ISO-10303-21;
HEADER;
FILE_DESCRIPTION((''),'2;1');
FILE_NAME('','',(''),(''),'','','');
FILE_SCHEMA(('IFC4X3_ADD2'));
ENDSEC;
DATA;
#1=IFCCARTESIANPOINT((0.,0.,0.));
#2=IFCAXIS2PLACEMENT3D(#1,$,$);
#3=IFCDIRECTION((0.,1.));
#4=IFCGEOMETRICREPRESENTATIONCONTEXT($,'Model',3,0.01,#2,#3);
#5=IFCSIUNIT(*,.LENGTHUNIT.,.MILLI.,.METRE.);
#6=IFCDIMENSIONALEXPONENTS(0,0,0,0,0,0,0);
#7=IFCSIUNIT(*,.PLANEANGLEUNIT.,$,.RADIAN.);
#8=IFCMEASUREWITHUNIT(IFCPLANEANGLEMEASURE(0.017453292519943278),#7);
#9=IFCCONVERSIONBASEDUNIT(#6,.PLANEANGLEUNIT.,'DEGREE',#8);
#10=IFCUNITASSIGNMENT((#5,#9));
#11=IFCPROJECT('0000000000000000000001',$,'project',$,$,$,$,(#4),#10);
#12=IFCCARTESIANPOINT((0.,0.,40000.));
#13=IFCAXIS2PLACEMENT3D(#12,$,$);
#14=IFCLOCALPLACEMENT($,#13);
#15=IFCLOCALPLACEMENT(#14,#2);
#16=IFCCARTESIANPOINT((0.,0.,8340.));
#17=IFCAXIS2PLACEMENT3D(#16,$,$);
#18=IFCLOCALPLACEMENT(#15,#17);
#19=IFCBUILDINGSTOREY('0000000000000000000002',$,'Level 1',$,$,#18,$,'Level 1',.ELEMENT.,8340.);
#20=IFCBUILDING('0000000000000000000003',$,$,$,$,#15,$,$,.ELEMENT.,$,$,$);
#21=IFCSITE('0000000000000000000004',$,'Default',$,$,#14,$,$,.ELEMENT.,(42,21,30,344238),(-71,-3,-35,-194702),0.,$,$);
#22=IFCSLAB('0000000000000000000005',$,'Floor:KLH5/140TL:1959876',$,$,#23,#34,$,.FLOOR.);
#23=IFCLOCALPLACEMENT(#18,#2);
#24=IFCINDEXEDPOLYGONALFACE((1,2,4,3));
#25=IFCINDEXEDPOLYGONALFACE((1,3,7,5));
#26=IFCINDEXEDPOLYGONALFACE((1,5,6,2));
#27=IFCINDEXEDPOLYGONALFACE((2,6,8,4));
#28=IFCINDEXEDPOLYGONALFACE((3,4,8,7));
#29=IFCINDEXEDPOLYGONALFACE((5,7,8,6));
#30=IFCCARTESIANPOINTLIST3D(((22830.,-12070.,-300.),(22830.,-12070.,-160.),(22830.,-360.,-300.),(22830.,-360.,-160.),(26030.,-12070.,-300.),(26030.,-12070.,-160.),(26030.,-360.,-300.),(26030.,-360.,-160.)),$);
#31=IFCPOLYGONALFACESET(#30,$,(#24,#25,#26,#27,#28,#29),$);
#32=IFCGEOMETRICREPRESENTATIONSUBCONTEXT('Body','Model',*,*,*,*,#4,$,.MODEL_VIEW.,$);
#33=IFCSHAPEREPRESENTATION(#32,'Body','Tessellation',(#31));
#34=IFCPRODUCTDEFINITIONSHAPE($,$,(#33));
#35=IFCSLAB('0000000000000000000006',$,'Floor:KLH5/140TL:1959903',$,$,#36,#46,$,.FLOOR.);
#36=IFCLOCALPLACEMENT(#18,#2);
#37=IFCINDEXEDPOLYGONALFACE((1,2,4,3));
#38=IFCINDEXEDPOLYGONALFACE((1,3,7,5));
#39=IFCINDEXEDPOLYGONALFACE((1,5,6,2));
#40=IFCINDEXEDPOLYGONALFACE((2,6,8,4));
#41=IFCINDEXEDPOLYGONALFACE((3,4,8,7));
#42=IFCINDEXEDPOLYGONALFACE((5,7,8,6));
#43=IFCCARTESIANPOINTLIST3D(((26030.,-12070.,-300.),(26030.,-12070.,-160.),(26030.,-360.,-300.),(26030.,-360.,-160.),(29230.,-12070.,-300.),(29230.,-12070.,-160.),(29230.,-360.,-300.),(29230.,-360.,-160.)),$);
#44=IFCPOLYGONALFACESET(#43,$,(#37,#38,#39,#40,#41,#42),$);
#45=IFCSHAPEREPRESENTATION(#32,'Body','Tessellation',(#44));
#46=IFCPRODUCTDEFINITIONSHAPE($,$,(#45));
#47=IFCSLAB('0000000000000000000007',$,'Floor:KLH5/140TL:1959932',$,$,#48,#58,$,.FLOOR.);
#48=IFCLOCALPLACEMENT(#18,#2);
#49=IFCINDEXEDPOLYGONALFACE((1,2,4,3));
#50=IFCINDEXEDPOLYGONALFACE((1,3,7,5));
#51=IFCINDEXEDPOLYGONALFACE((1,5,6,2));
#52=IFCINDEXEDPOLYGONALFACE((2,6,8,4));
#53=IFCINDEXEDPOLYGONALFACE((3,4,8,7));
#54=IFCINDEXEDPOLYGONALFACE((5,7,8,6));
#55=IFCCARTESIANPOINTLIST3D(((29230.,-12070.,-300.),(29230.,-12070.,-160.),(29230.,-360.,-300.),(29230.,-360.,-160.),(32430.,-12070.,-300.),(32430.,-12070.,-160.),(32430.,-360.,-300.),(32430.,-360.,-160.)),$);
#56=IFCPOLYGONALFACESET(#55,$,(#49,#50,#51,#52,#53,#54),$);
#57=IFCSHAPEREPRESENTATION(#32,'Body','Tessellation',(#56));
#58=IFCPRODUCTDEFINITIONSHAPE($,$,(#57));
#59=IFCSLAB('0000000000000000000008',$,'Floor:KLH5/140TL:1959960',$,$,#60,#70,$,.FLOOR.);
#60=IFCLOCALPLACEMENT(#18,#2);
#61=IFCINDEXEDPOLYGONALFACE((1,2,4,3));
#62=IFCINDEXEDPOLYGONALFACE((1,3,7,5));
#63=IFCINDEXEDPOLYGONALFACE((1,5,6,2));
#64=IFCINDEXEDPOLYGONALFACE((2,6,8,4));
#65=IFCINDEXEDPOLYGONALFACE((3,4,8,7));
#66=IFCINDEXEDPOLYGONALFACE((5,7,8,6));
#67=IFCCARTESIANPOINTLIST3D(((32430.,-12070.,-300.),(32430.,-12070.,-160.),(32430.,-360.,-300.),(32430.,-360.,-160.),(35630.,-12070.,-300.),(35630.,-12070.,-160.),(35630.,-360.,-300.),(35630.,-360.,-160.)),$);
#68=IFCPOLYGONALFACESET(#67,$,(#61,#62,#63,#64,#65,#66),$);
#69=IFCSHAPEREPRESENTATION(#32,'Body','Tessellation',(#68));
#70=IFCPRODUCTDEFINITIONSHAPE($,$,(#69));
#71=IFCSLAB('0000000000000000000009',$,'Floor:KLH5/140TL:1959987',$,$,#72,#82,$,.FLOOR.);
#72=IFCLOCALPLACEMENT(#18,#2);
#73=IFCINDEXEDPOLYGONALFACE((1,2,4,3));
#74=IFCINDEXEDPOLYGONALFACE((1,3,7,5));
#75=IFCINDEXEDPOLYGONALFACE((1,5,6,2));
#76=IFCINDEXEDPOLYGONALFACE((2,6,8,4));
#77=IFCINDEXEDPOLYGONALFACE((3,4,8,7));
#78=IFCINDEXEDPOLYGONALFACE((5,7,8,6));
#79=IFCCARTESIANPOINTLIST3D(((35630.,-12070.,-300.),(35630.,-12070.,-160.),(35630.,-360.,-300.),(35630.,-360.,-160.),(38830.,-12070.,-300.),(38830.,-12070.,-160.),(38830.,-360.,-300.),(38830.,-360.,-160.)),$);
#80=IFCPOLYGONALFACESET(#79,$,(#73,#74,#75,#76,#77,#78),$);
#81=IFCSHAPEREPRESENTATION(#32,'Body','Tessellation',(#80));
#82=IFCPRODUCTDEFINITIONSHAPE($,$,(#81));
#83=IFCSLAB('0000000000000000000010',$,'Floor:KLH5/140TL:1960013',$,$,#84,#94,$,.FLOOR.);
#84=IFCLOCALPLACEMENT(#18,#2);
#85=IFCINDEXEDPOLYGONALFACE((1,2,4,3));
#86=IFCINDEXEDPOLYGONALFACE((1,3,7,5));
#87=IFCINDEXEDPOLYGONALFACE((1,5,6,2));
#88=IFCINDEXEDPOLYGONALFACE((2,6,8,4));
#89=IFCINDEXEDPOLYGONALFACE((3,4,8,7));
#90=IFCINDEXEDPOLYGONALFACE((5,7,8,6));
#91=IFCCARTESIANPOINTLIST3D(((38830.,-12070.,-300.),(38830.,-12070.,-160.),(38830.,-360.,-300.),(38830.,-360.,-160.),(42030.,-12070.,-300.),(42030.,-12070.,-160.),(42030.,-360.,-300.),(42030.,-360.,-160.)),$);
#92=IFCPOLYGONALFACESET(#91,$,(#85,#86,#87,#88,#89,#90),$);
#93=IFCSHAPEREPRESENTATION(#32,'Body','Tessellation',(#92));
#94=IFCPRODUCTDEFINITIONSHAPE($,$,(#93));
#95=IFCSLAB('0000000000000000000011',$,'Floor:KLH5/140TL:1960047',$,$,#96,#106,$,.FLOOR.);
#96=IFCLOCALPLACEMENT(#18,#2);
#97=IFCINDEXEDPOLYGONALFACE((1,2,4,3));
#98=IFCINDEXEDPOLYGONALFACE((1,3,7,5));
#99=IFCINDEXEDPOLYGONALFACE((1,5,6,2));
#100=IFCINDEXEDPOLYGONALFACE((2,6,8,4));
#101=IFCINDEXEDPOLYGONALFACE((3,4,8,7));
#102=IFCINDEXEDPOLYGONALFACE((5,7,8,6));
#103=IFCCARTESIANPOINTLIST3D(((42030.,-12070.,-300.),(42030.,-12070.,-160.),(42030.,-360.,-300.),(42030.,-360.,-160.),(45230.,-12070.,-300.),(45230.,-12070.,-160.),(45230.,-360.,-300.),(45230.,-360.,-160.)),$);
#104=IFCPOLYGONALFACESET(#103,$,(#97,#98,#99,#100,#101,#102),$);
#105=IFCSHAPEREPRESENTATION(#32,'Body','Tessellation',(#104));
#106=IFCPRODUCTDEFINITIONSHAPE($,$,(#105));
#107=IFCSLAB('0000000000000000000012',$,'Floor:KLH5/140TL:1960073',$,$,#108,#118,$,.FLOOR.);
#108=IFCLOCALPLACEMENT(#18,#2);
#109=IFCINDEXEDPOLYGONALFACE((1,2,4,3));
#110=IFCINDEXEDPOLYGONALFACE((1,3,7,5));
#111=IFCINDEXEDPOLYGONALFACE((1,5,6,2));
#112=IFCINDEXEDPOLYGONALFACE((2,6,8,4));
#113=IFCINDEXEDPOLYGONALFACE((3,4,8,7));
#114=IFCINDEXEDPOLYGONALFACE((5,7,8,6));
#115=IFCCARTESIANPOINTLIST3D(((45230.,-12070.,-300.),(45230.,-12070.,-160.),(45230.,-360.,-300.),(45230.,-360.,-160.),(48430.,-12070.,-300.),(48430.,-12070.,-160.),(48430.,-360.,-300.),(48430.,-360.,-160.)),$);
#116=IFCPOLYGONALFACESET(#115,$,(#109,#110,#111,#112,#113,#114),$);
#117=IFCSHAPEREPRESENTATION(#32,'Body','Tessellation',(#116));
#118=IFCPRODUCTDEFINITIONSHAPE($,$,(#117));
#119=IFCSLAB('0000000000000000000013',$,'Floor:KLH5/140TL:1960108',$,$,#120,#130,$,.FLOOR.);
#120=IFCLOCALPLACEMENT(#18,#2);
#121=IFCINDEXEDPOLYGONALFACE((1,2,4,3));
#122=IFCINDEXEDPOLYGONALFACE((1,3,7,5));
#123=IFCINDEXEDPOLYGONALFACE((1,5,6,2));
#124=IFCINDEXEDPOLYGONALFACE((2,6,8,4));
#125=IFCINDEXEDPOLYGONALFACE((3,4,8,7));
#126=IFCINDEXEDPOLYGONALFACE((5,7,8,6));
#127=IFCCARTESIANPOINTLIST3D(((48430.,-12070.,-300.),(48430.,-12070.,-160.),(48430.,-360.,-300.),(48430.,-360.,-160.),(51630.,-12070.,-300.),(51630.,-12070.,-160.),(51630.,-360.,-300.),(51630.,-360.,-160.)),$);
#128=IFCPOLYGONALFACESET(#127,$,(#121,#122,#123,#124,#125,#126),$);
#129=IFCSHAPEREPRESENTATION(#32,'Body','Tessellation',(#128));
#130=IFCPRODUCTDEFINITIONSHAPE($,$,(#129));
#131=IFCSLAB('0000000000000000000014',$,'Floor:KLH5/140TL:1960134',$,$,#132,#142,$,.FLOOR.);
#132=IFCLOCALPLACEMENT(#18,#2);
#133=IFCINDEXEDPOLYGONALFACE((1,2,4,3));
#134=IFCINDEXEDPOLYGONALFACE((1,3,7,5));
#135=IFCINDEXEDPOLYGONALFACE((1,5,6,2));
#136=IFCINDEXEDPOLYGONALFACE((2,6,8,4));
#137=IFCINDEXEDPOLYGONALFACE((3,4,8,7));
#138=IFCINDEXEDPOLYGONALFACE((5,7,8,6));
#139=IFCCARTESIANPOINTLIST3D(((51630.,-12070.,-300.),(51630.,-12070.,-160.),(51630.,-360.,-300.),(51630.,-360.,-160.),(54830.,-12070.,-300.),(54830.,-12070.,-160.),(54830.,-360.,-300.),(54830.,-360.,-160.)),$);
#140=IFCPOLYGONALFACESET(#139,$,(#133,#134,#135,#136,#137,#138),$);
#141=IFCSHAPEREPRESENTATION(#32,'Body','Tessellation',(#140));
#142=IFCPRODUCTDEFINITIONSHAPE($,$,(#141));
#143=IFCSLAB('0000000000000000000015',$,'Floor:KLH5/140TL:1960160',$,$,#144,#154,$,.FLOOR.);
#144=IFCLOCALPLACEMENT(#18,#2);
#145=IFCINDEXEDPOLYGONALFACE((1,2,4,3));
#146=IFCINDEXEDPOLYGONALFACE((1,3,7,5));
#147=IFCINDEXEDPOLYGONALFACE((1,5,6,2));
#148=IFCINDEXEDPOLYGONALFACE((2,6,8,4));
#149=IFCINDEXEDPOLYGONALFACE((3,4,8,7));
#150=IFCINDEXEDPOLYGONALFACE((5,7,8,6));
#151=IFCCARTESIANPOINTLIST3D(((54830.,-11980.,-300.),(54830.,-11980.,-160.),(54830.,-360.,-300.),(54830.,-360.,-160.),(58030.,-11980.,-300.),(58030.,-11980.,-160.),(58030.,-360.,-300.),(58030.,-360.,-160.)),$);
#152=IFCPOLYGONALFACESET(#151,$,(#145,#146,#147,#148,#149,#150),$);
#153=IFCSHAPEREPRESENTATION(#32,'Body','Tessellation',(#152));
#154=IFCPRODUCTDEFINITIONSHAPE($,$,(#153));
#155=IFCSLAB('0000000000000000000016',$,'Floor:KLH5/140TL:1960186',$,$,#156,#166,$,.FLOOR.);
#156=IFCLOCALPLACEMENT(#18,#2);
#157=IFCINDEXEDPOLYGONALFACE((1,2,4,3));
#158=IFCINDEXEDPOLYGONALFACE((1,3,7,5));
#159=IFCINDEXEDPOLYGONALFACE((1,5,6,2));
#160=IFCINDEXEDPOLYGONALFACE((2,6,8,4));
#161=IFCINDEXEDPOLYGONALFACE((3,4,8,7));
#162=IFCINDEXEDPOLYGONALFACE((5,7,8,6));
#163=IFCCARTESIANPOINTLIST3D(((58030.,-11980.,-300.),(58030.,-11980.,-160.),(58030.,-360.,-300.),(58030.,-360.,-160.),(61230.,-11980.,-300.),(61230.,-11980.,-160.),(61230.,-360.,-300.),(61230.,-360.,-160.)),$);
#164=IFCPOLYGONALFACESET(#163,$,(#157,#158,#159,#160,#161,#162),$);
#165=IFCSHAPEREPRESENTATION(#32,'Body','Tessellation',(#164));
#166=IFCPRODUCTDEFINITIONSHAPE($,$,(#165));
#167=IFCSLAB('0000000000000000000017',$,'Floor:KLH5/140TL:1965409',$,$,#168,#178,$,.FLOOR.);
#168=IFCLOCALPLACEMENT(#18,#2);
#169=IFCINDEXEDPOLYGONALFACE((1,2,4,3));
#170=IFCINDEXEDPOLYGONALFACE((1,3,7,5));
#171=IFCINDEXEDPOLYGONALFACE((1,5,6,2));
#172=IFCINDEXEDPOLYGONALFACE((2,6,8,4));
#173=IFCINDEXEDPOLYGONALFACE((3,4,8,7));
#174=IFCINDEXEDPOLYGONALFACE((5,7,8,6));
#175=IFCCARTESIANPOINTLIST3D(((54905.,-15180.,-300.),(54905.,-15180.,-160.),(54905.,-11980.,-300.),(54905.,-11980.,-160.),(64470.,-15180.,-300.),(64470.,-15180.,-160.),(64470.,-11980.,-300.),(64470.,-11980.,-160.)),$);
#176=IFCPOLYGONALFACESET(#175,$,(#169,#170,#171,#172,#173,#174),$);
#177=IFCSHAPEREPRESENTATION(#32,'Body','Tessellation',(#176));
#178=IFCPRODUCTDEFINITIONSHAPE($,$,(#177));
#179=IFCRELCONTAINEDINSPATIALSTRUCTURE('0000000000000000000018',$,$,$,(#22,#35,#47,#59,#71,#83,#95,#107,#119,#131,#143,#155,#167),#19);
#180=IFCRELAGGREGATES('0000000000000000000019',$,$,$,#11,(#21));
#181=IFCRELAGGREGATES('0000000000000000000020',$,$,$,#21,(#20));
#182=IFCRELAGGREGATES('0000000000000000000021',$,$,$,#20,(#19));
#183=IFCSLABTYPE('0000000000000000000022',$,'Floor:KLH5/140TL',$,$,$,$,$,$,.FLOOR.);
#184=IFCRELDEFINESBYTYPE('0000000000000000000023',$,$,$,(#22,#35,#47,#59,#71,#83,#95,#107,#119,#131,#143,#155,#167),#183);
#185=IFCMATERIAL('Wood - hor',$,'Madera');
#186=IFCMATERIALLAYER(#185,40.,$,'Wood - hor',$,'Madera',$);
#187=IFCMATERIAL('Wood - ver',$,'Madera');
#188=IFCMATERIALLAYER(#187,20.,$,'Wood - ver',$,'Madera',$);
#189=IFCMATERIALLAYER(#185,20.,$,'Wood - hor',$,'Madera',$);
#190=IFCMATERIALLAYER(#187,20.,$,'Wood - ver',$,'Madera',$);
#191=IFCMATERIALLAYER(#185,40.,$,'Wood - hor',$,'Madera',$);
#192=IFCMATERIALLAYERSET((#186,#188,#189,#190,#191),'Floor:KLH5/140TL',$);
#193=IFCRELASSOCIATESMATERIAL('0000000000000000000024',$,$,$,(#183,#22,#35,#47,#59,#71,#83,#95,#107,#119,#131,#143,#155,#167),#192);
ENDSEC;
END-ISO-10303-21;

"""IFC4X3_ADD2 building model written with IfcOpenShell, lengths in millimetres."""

from ifc_helpers import new_model, entity, si_unit, converted_unit, direction, frame, frame_2d, origin, origin_2d_with_axis, place, context, subcontext, project, spatial, rectangle, extrude, material, layer, layer_set, layer_usage, type_object, element, save


model = new_model("IFC4X3_ADD2")

# Units and contexts
model_context = context("Model", 3, precision=0.01, world=origin(), true_north=direction((0.0, 1.0)))
body_context = subcontext(model_context, "Body", "Model", "MODEL_VIEW")
ifc_project = project(units=[si_unit("LENGTHUNIT", "METRE", prefix="MILLI"), converted_unit("PLANEANGLEUNIT", "DEGREE", entity("IfcPlaneAngleMeasure", 0.017453292519943278), si_unit("PLANEANGLEUNIT", "RADIAN"), dimensions=[0, 0, 0, 0, 0, 0, 0])], contexts=[model_context])

# Site, building, storey
site_placement = place(None, frame((0.0, 0.0, 40000.0)))
site = spatial("IfcSite", under=ifc_project, at=site_placement, Name="Default", CompositionType="ELEMENT", RefLatitude=(42, 21, 30, 344238), RefLongitude=(-71, -3, -35, -194702), RefElevation=0.0)
building_placement = place(site_placement, origin())
building = spatial("IfcBuilding", under=site, at=building_placement, CompositionType="ELEMENT")
storey_placement = place(building_placement, frame((0.0, 0.0, 8340.0)))
storey = spatial("IfcBuildingStorey", under=building, at=storey_placement, Name="Level 1", LongName="Level 1", CompositionType="ELEMENT", Elevation=8340.0)

# Slabs
ifc_material_1 = material(Name="Wood - hor", Category="Madera")
ifc_layer_1 = layer(ifc_material_1, 40.0, Name="Wood - hor", Category="Madera")
ifc_material_2 = material(Name="Wood - ver", Category="Madera")
ifc_layer_2 = layer(ifc_material_2, 20.0, Name="Wood - ver", Category="Madera")
ifc_layer_3 = layer(ifc_material_1, 20.0, Name="Wood - hor", Category="Madera")
ifc_layer_4 = layer(ifc_material_2, 20.0, Name="Wood - ver", Category="Madera")
ifc_layer_5 = layer(ifc_material_1, 40.0, Name="Wood - hor", Category="Madera")
ifc_layer_set = layer_set([ifc_layer_1, ifc_layer_2, ifc_layer_3, ifc_layer_4, ifc_layer_5], Name="Floor:KLH5/140TL")
slab_type = type_object("IfcSlabType", Name="Floor:KLH5/140TL", PredefinedType="FLOOR", material=ifc_layer_set)
ifc_layer_usage_1 = layer_usage(ifc_layer_set, "AXIS3", "POSITIVE", 0.0)
slab_1_placement = place(storey_placement, origin())
element("IfcSlab", 1, at=slab_1_placement, inside=storey, type_object=slab_type, material=ifc_layer_usage_1, Name="Floor:KLH5/140TL:1959876", PredefinedType="FLOOR", context=body_context, shape_type="SweptSolid", body=[
    extrude(rectangle(XDim=11710.0, YDim=3200.0, at=frame_2d((0.0, 0.0), x_axis=(1.0, 0.0))), frame((24430.0, -6215.0, -160.0), z_axis=(0.0, 0.0, -1.0), x_axis=(0.0, 1.0, 0.0)), (0.0, 0.0, 1.0), 140.0),
])
ifc_layer_usage_2 = layer_usage(ifc_layer_set, "AXIS3", "POSITIVE", 0.0)
slab_2_placement = place(storey_placement, origin())
element("IfcSlab", 2, at=slab_2_placement, inside=storey, type_object=slab_type, material=ifc_layer_usage_2, Name="Floor:KLH5/140TL:1959903", PredefinedType="FLOOR", context=body_context, shape_type="SweptSolid", body=[
    extrude(rectangle(XDim=11710.0, YDim=3200.0, at=origin_2d_with_axis()), frame((27630.0, -6215.0, -160.0), z_axis=(0.0, 0.0, -1.0), x_axis=(0.0, 1.0, 0.0)), (0.0, 0.0, 1.0), 140.0),
])
ifc_layer_usage_3 = layer_usage(ifc_layer_set, "AXIS3", "POSITIVE", 0.0)
slab_3_placement = place(storey_placement, origin())
element("IfcSlab", 3, at=slab_3_placement, inside=storey, type_object=slab_type, material=ifc_layer_usage_3, Name="Floor:KLH5/140TL:1959932", PredefinedType="FLOOR", context=body_context, shape_type="SweptSolid", body=[
    extrude(rectangle(XDim=11710.0, YDim=3200.0, at=origin_2d_with_axis()), frame((30830.0, -6215.0, -160.0), z_axis=(0.0, 0.0, -1.0), x_axis=(0.0, 1.0, 0.0)), (0.0, 0.0, 1.0), 140.0),
])
ifc_layer_usage_4 = layer_usage(ifc_layer_set, "AXIS3", "POSITIVE", 0.0)
slab_4_placement = place(storey_placement, origin())
element("IfcSlab", 4, at=slab_4_placement, inside=storey, type_object=slab_type, material=ifc_layer_usage_4, Name="Floor:KLH5/140TL:1959960", PredefinedType="FLOOR", context=body_context, shape_type="SweptSolid", body=[
    extrude(rectangle(XDim=11710.0, YDim=3200.0, at=frame_2d((0.0, 0.0), x_axis=(1.0, 0.0))), frame((34030.0, -6215.0, -160.0), z_axis=(0.0, 0.0, -1.0), x_axis=(0.0, 1.0, 0.0)), (0.0, 0.0, 1.0), 140.0),
])
ifc_layer_usage_5 = layer_usage(ifc_layer_set, "AXIS3", "POSITIVE", 0.0)
slab_5_placement = place(storey_placement, origin())
element("IfcSlab", 5, at=slab_5_placement, inside=storey, type_object=slab_type, material=ifc_layer_usage_5, Name="Floor:KLH5/140TL:1959987", PredefinedType="FLOOR", context=body_context, shape_type="SweptSolid", body=[
    extrude(rectangle(XDim=11710.0, YDim=3200.0, at=origin_2d_with_axis()), frame((37230.0, -6215.0, -160.0), z_axis=(0.0, 0.0, -1.0), x_axis=(0.0, 1.0, 0.0)), (0.0, 0.0, 1.0), 140.0),
])
ifc_layer_usage_6 = layer_usage(ifc_layer_set, "AXIS3", "POSITIVE", 0.0)
slab_6_placement = place(storey_placement, origin())
element("IfcSlab", 6, at=slab_6_placement, inside=storey, type_object=slab_type, material=ifc_layer_usage_6, Name="Floor:KLH5/140TL:1960013", PredefinedType="FLOOR", context=body_context, shape_type="SweptSolid", body=[
    extrude(rectangle(XDim=11710.0, YDim=3200.0, at=frame_2d((0.0, 0.0), x_axis=(1.0, 0.0))), frame((40430.0, -6215.0, -160.0), z_axis=(0.0, 0.0, -1.0), x_axis=(0.0, 1.0, 0.0)), (0.0, 0.0, 1.0), 140.0),
])
ifc_layer_usage_7 = layer_usage(ifc_layer_set, "AXIS3", "POSITIVE", 0.0)
slab_7_placement = place(storey_placement, origin())
element("IfcSlab", 7, at=slab_7_placement, inside=storey, type_object=slab_type, material=ifc_layer_usage_7, Name="Floor:KLH5/140TL:1960047", PredefinedType="FLOOR", context=body_context, shape_type="SweptSolid", body=[
    extrude(rectangle(XDim=11710.0, YDim=3200.0, at=origin_2d_with_axis()), frame((43630.0, -6215.0, -160.0), z_axis=(0.0, 0.0, -1.0), x_axis=(0.0, 1.0, 0.0)), (0.0, 0.0, 1.0), 140.0),
])
ifc_layer_usage_8 = layer_usage(ifc_layer_set, "AXIS3", "POSITIVE", 0.0)
slab_8_placement = place(storey_placement, origin())
element("IfcSlab", 8, at=slab_8_placement, inside=storey, type_object=slab_type, material=ifc_layer_usage_8, Name="Floor:KLH5/140TL:1960073", PredefinedType="FLOOR", context=body_context, shape_type="SweptSolid", body=[
    extrude(rectangle(XDim=11710.0, YDim=3200.0, at=origin_2d_with_axis()), frame((46830.0, -6215.0, -160.0), z_axis=(0.0, 0.0, -1.0), x_axis=(0.0, 1.0, 0.0)), (0.0, 0.0, 1.0), 140.0),
])
ifc_layer_usage_9 = layer_usage(ifc_layer_set, "AXIS3", "POSITIVE", 0.0)
slab_9_placement = place(storey_placement, origin())
element("IfcSlab", 9, at=slab_9_placement, inside=storey, type_object=slab_type, material=ifc_layer_usage_9, Name="Floor:KLH5/140TL:1960108", PredefinedType="FLOOR", context=body_context, shape_type="SweptSolid", body=[
    extrude(rectangle(XDim=11710.0, YDim=3200.0, at=origin_2d_with_axis()), frame((50030.0, -6215.0, -160.0), z_axis=(0.0, 0.0, -1.0), x_axis=(0.0, 1.0, 0.0)), (0.0, 0.0, 1.0), 140.0),
])
ifc_layer_usage_10 = layer_usage(ifc_layer_set, "AXIS3", "POSITIVE", 0.0)
slab_10_placement = place(storey_placement, origin())
element("IfcSlab", 10, at=slab_10_placement, inside=storey, type_object=slab_type, material=ifc_layer_usage_10, Name="Floor:KLH5/140TL:1960134", PredefinedType="FLOOR", context=body_context, shape_type="SweptSolid", body=[
    extrude(rectangle(XDim=11710.0, YDim=3200.0, at=origin_2d_with_axis()), frame((53230.0, -6215.0, -160.0), z_axis=(0.0, 0.0, -1.0), x_axis=(0.0, 1.0, 0.0)), (0.0, 0.0, 1.0), 140.0),
])
ifc_layer_usage_11 = layer_usage(ifc_layer_set, "AXIS3", "POSITIVE", 0.0)
slab_11_placement = place(storey_placement, origin())
element("IfcSlab", 11, at=slab_11_placement, inside=storey, type_object=slab_type, material=ifc_layer_usage_11, Name="Floor:KLH5/140TL:1960160", PredefinedType="FLOOR", context=body_context, shape_type="SweptSolid", body=[
    extrude(rectangle(XDim=11620.0, YDim=3200.0, at=origin_2d_with_axis()), frame((56430.0, -6170.0, -160.0), z_axis=(0.0, 0.0, -1.0), x_axis=(0.0, 1.0, 0.0)), (0.0, 0.0, 1.0), 140.0),
])
ifc_layer_usage_12 = layer_usage(ifc_layer_set, "AXIS3", "POSITIVE", 0.0)
slab_12_placement = place(storey_placement, origin())
element("IfcSlab", 12, at=slab_12_placement, inside=storey, type_object=slab_type, material=ifc_layer_usage_12, Name="Floor:KLH5/140TL:1960186", PredefinedType="FLOOR", context=body_context, shape_type="SweptSolid", body=[
    extrude(rectangle(XDim=11620.0, YDim=3200.0, at=frame_2d((0.0, 0.0), x_axis=(1.0, 0.0))), frame((59630.0, -6170.0, -160.0), z_axis=(0.0, 0.0, -1.0), x_axis=(0.0, 1.0, 0.0)), (0.0, 0.0, 1.0), 140.0),
])
ifc_layer_usage_13 = layer_usage(ifc_layer_set, "AXIS3", "POSITIVE", 0.0)
slab_13_placement = place(storey_placement, origin())
element("IfcSlab", 13, at=slab_13_placement, inside=storey, type_object=slab_type, material=ifc_layer_usage_13, Name="Floor:KLH5/140TL:1965409", PredefinedType="FLOOR", context=body_context, shape_type="SweptSolid", body=[
    extrude(rectangle(XDim=3200.0, YDim=9565.0, at=frame_2d((0.0, 0.0), x_axis=(1.0, 0.0))), frame((59687.5, -13580.0, -160.0), z_axis=(0.0, 0.0, -1.0), x_axis=(0.0, 1.0, 0.0)), (0.0, 0.0, 1.0), 140.0),
])

save(model, "model.ifc")
